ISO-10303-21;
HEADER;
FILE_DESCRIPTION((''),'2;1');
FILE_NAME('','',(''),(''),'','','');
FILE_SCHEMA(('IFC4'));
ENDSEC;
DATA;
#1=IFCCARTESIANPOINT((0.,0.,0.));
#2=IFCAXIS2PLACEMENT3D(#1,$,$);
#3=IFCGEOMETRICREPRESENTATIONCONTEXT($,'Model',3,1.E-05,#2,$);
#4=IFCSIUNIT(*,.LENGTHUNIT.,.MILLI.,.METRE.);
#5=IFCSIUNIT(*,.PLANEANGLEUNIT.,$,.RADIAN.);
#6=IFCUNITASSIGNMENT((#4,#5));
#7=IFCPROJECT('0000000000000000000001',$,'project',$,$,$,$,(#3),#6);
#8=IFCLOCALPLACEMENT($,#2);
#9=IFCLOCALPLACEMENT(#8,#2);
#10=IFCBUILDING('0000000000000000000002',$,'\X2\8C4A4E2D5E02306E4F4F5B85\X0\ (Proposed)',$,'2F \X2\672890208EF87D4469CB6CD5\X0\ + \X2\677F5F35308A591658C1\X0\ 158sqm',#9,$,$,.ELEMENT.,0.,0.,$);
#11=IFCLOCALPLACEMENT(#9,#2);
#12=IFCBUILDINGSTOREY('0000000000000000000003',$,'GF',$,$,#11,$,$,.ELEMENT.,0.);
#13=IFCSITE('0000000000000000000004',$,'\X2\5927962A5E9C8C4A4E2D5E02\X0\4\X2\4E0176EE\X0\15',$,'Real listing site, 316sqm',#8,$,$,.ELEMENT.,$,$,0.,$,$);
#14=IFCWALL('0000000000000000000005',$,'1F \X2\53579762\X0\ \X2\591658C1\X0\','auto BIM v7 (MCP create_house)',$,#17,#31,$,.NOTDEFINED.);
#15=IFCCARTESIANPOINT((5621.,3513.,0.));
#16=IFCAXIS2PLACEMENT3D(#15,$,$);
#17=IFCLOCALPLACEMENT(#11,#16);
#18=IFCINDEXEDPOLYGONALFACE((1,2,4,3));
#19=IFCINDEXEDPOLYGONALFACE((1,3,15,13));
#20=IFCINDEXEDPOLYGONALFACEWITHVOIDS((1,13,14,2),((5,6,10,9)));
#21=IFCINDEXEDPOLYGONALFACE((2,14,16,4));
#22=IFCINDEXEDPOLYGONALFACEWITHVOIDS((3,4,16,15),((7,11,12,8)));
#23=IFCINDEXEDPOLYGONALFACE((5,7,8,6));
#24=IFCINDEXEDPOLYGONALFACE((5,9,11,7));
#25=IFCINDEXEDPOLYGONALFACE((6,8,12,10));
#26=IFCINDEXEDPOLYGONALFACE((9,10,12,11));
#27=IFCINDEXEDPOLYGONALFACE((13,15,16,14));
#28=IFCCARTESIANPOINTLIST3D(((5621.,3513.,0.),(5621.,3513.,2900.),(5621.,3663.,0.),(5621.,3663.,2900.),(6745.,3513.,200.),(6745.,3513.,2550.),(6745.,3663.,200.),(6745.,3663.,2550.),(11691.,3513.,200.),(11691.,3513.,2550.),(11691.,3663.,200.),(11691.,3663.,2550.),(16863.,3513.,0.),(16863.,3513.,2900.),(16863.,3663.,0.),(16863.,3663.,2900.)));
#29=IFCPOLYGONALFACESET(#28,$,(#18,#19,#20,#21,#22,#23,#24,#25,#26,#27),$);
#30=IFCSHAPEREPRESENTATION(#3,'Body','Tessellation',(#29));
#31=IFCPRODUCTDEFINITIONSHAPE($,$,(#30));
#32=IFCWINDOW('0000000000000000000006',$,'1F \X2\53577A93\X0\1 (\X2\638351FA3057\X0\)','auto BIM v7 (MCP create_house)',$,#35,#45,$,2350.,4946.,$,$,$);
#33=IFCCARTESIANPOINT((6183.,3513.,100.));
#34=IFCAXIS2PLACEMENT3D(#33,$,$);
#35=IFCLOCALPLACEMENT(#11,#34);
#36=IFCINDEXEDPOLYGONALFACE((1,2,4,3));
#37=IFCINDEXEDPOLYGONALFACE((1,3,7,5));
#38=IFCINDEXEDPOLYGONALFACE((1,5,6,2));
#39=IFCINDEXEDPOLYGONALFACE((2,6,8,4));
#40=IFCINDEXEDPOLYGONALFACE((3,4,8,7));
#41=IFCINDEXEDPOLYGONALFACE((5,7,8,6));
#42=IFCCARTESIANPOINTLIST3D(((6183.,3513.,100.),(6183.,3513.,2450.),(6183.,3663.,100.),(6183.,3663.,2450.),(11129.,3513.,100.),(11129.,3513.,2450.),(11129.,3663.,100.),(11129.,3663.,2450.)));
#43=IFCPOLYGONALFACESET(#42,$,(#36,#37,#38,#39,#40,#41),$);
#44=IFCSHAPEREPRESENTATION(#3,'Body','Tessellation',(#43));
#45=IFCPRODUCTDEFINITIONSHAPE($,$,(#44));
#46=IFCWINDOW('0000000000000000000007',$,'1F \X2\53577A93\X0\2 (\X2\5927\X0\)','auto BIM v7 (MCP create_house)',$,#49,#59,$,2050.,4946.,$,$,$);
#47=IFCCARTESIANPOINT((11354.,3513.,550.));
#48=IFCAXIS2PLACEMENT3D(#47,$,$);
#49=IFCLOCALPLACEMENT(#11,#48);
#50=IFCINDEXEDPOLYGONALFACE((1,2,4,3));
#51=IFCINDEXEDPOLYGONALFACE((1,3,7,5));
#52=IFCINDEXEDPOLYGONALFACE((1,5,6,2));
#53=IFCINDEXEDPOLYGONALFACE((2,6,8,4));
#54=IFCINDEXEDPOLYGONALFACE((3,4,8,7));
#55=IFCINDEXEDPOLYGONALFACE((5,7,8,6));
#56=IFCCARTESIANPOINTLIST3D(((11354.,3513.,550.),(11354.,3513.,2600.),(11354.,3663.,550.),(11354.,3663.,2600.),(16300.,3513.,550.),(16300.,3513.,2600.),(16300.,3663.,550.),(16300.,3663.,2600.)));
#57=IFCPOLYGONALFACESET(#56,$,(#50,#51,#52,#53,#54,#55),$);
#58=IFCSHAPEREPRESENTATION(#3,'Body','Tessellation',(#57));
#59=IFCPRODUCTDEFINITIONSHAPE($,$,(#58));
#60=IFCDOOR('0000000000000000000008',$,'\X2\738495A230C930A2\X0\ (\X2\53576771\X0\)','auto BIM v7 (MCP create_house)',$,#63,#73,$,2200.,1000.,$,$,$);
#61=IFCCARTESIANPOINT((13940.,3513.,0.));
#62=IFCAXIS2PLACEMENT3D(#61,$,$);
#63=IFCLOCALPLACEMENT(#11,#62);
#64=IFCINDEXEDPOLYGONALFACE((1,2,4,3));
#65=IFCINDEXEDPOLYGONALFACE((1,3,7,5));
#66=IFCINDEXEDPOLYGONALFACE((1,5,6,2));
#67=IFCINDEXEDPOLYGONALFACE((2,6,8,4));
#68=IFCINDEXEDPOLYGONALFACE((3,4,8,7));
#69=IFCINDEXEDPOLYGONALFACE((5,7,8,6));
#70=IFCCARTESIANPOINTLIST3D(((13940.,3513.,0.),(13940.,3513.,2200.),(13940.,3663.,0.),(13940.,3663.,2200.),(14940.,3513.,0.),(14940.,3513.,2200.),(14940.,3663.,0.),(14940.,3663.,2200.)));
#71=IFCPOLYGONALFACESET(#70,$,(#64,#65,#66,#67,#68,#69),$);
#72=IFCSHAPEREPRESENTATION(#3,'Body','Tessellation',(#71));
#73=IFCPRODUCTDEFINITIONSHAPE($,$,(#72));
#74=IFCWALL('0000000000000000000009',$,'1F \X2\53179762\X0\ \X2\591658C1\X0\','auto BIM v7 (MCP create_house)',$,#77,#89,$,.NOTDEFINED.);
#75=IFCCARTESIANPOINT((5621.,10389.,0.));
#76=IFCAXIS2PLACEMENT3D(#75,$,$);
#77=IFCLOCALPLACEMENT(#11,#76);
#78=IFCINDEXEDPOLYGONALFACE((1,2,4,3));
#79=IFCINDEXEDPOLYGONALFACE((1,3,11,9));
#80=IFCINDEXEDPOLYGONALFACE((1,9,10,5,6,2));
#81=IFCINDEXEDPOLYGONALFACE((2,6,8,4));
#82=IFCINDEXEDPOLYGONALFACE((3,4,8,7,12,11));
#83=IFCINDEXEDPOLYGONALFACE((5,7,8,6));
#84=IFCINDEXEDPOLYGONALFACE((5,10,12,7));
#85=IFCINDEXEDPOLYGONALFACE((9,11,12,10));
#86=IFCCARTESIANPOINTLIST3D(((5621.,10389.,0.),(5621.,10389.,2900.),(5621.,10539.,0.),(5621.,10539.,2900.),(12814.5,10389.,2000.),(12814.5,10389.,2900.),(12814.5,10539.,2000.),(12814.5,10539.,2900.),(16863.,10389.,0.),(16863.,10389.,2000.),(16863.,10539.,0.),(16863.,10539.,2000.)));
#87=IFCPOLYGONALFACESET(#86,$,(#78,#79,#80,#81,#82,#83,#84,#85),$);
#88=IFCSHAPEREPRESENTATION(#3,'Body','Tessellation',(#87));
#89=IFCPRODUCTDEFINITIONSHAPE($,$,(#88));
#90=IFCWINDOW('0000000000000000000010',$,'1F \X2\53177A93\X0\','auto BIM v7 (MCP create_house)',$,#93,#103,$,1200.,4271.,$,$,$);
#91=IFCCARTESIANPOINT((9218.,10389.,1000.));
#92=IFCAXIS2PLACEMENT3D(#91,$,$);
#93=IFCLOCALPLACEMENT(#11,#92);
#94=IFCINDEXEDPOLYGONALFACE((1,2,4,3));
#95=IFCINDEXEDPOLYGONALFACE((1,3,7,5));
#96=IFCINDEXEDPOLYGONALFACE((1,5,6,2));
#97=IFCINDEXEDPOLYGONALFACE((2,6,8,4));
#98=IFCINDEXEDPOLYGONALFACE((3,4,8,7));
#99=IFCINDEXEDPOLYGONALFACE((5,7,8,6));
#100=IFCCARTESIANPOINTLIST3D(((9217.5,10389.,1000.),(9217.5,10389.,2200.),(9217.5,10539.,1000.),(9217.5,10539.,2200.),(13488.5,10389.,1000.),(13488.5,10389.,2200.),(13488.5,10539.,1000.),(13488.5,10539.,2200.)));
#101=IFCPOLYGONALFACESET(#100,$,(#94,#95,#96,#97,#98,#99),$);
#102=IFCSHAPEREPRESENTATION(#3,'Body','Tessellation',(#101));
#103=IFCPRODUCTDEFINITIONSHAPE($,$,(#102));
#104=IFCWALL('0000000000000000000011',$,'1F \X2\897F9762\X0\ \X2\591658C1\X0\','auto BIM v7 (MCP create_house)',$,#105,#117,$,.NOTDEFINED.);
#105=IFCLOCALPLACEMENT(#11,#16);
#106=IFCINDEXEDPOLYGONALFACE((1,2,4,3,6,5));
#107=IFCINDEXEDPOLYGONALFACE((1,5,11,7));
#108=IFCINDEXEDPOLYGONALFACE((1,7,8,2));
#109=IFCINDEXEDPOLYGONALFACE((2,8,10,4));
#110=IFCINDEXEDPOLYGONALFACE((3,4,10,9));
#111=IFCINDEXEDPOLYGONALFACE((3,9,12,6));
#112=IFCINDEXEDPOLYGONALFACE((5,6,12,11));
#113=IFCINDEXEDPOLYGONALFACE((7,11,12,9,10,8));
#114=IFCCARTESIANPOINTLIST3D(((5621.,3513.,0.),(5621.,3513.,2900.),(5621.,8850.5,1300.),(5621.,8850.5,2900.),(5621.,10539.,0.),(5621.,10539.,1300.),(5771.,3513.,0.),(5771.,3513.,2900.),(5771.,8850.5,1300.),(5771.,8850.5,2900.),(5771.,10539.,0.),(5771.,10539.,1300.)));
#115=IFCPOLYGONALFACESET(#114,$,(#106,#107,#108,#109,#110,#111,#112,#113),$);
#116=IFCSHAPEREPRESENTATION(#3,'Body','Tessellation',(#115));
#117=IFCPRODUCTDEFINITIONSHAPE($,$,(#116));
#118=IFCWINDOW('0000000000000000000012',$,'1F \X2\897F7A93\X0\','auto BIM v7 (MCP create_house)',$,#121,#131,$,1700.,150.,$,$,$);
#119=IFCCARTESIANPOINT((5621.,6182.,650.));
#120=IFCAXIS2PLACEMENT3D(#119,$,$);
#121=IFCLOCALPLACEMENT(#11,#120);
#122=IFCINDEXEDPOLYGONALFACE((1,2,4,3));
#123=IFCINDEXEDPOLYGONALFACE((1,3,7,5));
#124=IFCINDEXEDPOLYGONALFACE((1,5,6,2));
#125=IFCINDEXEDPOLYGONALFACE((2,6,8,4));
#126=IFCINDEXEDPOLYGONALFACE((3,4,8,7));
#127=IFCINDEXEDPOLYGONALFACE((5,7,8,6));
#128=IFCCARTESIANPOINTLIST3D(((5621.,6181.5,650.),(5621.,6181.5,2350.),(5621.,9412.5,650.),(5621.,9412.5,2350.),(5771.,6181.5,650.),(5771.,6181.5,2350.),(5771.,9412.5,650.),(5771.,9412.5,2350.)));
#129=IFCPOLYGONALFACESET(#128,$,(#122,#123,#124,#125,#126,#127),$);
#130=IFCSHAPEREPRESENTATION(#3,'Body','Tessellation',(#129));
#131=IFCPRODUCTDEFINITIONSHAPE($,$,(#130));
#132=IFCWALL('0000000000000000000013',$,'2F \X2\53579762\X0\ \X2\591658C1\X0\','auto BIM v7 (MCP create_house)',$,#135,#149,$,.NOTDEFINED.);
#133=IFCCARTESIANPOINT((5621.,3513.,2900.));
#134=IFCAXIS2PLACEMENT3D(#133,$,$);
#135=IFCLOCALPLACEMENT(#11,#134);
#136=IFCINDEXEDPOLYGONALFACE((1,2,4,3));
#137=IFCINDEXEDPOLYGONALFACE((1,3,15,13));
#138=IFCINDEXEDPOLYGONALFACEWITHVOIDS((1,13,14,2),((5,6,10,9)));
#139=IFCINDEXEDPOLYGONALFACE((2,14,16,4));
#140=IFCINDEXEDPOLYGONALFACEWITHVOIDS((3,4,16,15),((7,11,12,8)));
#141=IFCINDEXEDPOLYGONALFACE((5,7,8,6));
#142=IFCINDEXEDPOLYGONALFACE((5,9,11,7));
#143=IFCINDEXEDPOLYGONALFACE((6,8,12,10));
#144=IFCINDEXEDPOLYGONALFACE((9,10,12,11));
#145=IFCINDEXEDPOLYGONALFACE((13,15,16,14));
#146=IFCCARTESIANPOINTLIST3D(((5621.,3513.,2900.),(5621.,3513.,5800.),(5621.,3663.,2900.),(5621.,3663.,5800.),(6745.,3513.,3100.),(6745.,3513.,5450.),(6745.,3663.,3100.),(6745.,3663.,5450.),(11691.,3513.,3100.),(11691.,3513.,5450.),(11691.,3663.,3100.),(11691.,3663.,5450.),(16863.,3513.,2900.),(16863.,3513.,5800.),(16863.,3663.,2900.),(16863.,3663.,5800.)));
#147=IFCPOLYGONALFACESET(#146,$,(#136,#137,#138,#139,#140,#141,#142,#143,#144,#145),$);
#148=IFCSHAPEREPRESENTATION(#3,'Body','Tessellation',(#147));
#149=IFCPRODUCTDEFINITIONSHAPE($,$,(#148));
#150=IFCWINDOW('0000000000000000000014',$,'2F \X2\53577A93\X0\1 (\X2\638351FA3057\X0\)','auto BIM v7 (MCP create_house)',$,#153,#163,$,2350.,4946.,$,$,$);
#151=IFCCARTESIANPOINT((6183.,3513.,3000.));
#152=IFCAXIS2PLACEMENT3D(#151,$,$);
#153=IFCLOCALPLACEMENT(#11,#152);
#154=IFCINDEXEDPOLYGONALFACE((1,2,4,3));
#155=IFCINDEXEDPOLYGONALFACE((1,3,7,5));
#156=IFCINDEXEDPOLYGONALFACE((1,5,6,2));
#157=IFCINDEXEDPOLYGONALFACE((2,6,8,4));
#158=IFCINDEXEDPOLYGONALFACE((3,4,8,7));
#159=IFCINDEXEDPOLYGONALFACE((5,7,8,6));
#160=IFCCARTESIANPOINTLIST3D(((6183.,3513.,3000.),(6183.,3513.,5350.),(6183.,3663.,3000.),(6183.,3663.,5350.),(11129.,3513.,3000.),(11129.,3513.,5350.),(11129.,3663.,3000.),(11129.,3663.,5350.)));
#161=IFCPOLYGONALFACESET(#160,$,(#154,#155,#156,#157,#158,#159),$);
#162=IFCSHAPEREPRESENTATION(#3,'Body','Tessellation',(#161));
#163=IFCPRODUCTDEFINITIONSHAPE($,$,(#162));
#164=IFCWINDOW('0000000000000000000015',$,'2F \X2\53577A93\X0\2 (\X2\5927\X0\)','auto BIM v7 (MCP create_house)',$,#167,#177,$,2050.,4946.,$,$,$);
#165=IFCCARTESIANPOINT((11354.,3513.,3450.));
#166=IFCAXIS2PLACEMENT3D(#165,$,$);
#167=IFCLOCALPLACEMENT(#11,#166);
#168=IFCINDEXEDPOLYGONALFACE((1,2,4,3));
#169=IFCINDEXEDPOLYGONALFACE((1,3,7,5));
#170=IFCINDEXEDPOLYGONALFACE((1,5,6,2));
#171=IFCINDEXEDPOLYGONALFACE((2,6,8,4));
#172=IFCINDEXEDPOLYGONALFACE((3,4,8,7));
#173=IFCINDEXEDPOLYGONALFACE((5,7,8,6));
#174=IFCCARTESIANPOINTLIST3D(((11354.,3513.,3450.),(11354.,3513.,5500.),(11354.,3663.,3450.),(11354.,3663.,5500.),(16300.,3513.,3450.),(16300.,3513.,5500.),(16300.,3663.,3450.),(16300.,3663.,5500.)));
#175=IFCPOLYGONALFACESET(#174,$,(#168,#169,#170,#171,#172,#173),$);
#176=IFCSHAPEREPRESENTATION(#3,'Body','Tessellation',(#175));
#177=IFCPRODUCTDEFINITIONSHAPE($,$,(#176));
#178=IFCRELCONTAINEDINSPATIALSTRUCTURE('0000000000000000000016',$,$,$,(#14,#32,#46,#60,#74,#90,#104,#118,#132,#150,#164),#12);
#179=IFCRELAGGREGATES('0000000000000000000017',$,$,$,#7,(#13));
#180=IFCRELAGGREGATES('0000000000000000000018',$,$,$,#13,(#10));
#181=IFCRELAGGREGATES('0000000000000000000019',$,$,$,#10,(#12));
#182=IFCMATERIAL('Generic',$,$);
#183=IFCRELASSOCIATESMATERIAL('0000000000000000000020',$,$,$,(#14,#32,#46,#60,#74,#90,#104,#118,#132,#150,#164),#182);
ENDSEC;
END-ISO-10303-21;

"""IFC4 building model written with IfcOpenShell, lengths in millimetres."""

from ifc_helpers import new_model, si_unit, frame, frame_2d, origin, place, context, project, spatial, rectangle, extrude, material, element, fill, save


model = new_model("IFC4")

# Units and contexts
model_context = context("Model", 3, precision=1e-05, world=origin())
ifc_project = project(units=[si_unit("LENGTHUNIT", "METRE", prefix="MILLI"), si_unit("PLANEANGLEUNIT", "RADIAN")], contexts=[model_context])

# Site, building, storey
site_placement = place(None, origin())
site = spatial("IfcSite", under=ifc_project, at=site_placement, Name="大阪府豊中市4丁目15", ObjectType="Real listing site, 316sqm", CompositionType="ELEMENT", RefElevation=0.0)
building_placement = place(site_placement, origin())
building = spatial("IfcBuilding", under=site, at=building_placement, Name="豊中市の住宅 (Proposed)", ObjectType="2F 木造軸組構法 + 板張り外壁 158sqm", CompositionType="ELEMENT", ElevationOfRefHeight=0.0, ElevationOfTerrain=0.0)
storey_placement = place(building_placement, origin())
storey = spatial("IfcBuildingStorey", under=building, at=storey_placement, Name="GF", CompositionType="ELEMENT", Elevation=0.0)

# Shared definitions
ifc_material = material(Name="Generic")

# Wall, openings, windows, door
wall_1_placement = place(storey_placement, frame((5621.0, 3513.0, 0.0)))
wall_1 = element("IfcWall", 1, at=wall_1_placement, inside=storey, material=ifc_material, Name="1F 南面 外壁", Description="auto BIM v7 (MCP create_house)", PredefinedType="NOTDEFINED", context=model_context, shape_type="SweptSolid", body=[
    extrude(rectangle(XDim=11242.0, YDim=150.0, at=frame_2d((5621.0, 75.0))), frame((5621.0, 3513.0, 0.0)), (0.0, 0.0, 1.0), 2900.0),
])
opening_1_placement = place(storey_placement, frame((6183.0, 3513.0, 100.0)))
opening_1 = element("IfcOpeningElement", 2, at=opening_1_placement, cuts=wall_1, PredefinedType="NOTDEFINED", context=model_context, shape_type="SweptSolid", body=[
    extrude(rectangle(XDim=4946.0, YDim=150.0, at=frame_2d((2473.0, 75.0))), frame((6183.0, 3513.0, 100.0)), (0.0, 0.0, 1.0), 2350.0),
])
opening_2_placement = place(storey_placement, frame((11354.0, 3513.0, 550.0)))
opening_2 = element("IfcOpeningElement", 3, at=opening_2_placement, cuts=wall_1, PredefinedType="NOTDEFINED", context=model_context, shape_type="SweptSolid", body=[
    extrude(rectangle(XDim=4946.0, YDim=150.0, at=frame_2d((2473.0, 75.0))), frame((11354.0, 3513.0, 550.0)), (0.0, 0.0, 1.0), 2050.0),
])
opening_3_placement = place(storey_placement, frame((13940.0, 3513.0, 0.0)))
opening_3 = element("IfcOpeningElement", 4, at=opening_3_placement, cuts=wall_1, PredefinedType="NOTDEFINED", context=model_context, shape_type="SweptSolid", body=[
    extrude(rectangle(XDim=1000.0, YDim=150.0, at=frame_2d((500.0, 75.0))), frame((13940.0, 3513.0, 0.0)), (0.0, 0.0, 1.0), 2200.0),
])
window_1_placement = place(storey_placement, frame((6183.0, 3513.0, 100.0)))
window_1 = element("IfcWindow", 5, at=window_1_placement, inside=storey, material=ifc_material, Name="1F 南窓1 (掃出し)", Description="auto BIM v7 (MCP create_house)", OverallHeight=2350.0, OverallWidth=4946.0, context=model_context, shape_type="SweptSolid", body=[
    extrude(rectangle(XDim=4946.0, YDim=150.0, at=frame_2d((2473.0, 75.0))), frame((6183.0, 3513.0, 100.0)), (0.0, 0.0, 1.0), 2350.0),
])
fill(opening_1, window_1)
window_2_placement = place(storey_placement, frame((11354.0, 3513.0, 550.0)))
window_2 = element("IfcWindow", 6, at=window_2_placement, inside=storey, material=ifc_material, Name="1F 南窓2 (大)", Description="auto BIM v7 (MCP create_house)", OverallHeight=2050.0, OverallWidth=4946.0, context=model_context, shape_type="SweptSolid", body=[
    extrude(rectangle(XDim=4946.0, YDim=150.0, at=frame_2d((2473.0, 75.0))), frame((11354.0, 3513.0, 550.0)), (0.0, 0.0, 1.0), 2050.0),
])
fill(opening_2, window_2)
door_placement = place(storey_placement, frame((13940.0, 3513.0, 0.0)))
door = element("IfcDoor", 7, at=door_placement, inside=storey, material=ifc_material, Name="玄関ドア (南東)", Description="auto BIM v7 (MCP create_house)", OverallHeight=2200.0, OverallWidth=1000.0, context=model_context, shape_type="SweptSolid", body=[
    extrude(rectangle(XDim=1000.0, YDim=150.0, at=frame_2d((500.0, 75.0))), frame((13940.0, 3513.0, 0.0)), (0.0, 0.0, 1.0), 2200.0),
])
fill(opening_3, door)

# Walls, openings, windows
wall_2_placement = place(storey_placement, frame((5621.0, 10389.0, 0.0)))
wall_2 = element("IfcWall", 8, at=wall_2_placement, inside=storey, material=ifc_material, Name="1F 北面 外壁", Description="auto BIM v7 (MCP create_house)", PredefinedType="NOTDEFINED", context=model_context, shape_type="SweptSolid", body=[
    extrude(rectangle(XDim=11242.0, YDim=150.0, at=frame_2d((5621.0, 75.0))), frame((5621.0, 10389.0, 0.0)), (0.0, 0.0, 1.0), 2900.0),
])
opening_4_placement = place(storey_placement, frame((9218.0, 10389.0, 1000.0)))
opening_4 = element("IfcOpeningElement", 9, at=opening_4_placement, cuts=wall_2, PredefinedType="NOTDEFINED", context=model_context, shape_type="SweptSolid", body=[
    extrude(rectangle(XDim=4271.0, YDim=150.0, at=frame_2d((2135.0, 75.0))), frame((9218.0, 10389.0, 1000.0)), (0.0, 0.0, 1.0), 1200.0),
])
window_3_placement = place(storey_placement, frame((9218.0, 10389.0, 1000.0)))
window_3 = element("IfcWindow", 10, at=window_3_placement, inside=storey, material=ifc_material, Name="1F 北窓", Description="auto BIM v7 (MCP create_house)", OverallHeight=1200.0, OverallWidth=4271.0, context=model_context, shape_type="SweptSolid", body=[
    extrude(rectangle(XDim=4271.0, YDim=150.0, at=frame_2d((2135.0, 75.0))), frame((9218.0, 10389.0, 1000.0)), (0.0, 0.0, 1.0), 1200.0),
])
fill(opening_4, window_3)
wall_3_placement = place(storey_placement, frame((5621.0, 3513.0, 0.0)))
wall_3 = element("IfcWall", 11, at=wall_3_placement, inside=storey, material=ifc_material, Name="1F 西面 外壁", Description="auto BIM v7 (MCP create_house)", PredefinedType="NOTDEFINED", context=model_context, shape_type="SweptSolid", body=[
    extrude(rectangle(XDim=150.0, YDim=7026.0, at=frame_2d((75.0, 3513.0))), frame((5621.0, 3513.0, 0.0)), (0.0, 0.0, 1.0), 2900.0),
])
opening_5_placement = place(storey_placement, frame((5621.0, 6182.0, 650.0)))
opening_5 = element("IfcOpeningElement", 12, at=opening_5_placement, cuts=wall_3, PredefinedType="NOTDEFINED", context=model_context, shape_type="SweptSolid", body=[
    extrude(rectangle(XDim=150.0, YDim=3231.0, at=frame_2d((75.0, 1615.0))), frame((5621.0, 6182.0, 650.0)), (0.0, 0.0, 1.0), 1700.0),
])
window_4_placement = place(storey_placement, frame((5621.0, 6182.0, 650.0)))
window_4 = element("IfcWindow", 13, at=window_4_placement, inside=storey, material=ifc_material, Name="1F 西窓", Description="auto BIM v7 (MCP create_house)", OverallHeight=1700.0, OverallWidth=150.0, context=model_context, shape_type="SweptSolid", body=[
    extrude(rectangle(XDim=150.0, YDim=3231.0, at=frame_2d((75.0, 1615.0))), frame((5621.0, 6182.0, 650.0)), (0.0, 0.0, 1.0), 1700.0),
])
fill(opening_5, window_4)

# Wall, openings, windows
wall_4_placement = place(storey_placement, frame((5621.0, 3513.0, 2900.0)))
wall_4 = element("IfcWall", 14, at=wall_4_placement, inside=storey, material=ifc_material, Name="2F 南面 外壁", Description="auto BIM v7 (MCP create_house)", PredefinedType="NOTDEFINED", context=model_context, shape_type="SweptSolid", body=[
    extrude(rectangle(XDim=11242.0, YDim=150.0, at=frame_2d((5621.0, 75.0))), frame((5621.0, 3513.0, 2900.0)), (0.0, 0.0, 1.0), 2900.0),
])
opening_6_placement = place(storey_placement, frame((6183.0, 3513.0, 3000.0)))
opening_6 = element("IfcOpeningElement", 15, at=opening_6_placement, cuts=wall_4, PredefinedType="NOTDEFINED", context=model_context, shape_type="SweptSolid", body=[
    extrude(rectangle(XDim=4946.0, YDim=150.0, at=frame_2d((2473.0, 75.0))), frame((6183.0, 3513.0, 3000.0)), (0.0, 0.0, 1.0), 2350.0),
])
opening_7_placement = place(storey_placement, frame((11354.0, 3513.0, 3450.0)))
opening_7 = element("IfcOpeningElement", 16, at=opening_7_placement, cuts=wall_4, PredefinedType="NOTDEFINED", context=model_context, shape_type="SweptSolid", body=[
    extrude(rectangle(XDim=4946.0, YDim=150.0, at=frame_2d((2473.0, 75.0))), frame((11354.0, 3513.0, 3450.0)), (0.0, 0.0, 1.0), 2050.0),
])
window_5_placement = place(storey_placement, frame((6183.0, 3513.0, 3000.0)))
window_5 = element("IfcWindow", 17, at=window_5_placement, inside=storey, material=ifc_material, Name="2F 南窓1 (掃出し)", Description="auto BIM v7 (MCP create_house)", OverallHeight=2350.0, OverallWidth=4946.0, context=model_context, shape_type="SweptSolid", body=[
    extrude(rectangle(XDim=4946.0, YDim=150.0, at=frame_2d((2473.0, 75.0))), frame((6183.0, 3513.0, 3000.0)), (0.0, 0.0, 1.0), 2350.0),
])
fill(opening_6, window_5)
window_6_placement = place(storey_placement, frame((11354.0, 3513.0, 3450.0)))
window_6 = element("IfcWindow", 18, at=window_6_placement, inside=storey, material=ifc_material, Name="2F 南窓2 (大)", Description="auto BIM v7 (MCP create_house)", OverallHeight=2050.0, OverallWidth=4946.0, context=model_context, shape_type="SweptSolid", body=[
    extrude(rectangle(XDim=4946.0, YDim=150.0, at=frame_2d((2473.0, 75.0))), frame((11354.0, 3513.0, 3450.0)), (0.0, 0.0, 1.0), 2050.0),
])
fill(opening_7, window_6)

save(model, "model.ifc")
